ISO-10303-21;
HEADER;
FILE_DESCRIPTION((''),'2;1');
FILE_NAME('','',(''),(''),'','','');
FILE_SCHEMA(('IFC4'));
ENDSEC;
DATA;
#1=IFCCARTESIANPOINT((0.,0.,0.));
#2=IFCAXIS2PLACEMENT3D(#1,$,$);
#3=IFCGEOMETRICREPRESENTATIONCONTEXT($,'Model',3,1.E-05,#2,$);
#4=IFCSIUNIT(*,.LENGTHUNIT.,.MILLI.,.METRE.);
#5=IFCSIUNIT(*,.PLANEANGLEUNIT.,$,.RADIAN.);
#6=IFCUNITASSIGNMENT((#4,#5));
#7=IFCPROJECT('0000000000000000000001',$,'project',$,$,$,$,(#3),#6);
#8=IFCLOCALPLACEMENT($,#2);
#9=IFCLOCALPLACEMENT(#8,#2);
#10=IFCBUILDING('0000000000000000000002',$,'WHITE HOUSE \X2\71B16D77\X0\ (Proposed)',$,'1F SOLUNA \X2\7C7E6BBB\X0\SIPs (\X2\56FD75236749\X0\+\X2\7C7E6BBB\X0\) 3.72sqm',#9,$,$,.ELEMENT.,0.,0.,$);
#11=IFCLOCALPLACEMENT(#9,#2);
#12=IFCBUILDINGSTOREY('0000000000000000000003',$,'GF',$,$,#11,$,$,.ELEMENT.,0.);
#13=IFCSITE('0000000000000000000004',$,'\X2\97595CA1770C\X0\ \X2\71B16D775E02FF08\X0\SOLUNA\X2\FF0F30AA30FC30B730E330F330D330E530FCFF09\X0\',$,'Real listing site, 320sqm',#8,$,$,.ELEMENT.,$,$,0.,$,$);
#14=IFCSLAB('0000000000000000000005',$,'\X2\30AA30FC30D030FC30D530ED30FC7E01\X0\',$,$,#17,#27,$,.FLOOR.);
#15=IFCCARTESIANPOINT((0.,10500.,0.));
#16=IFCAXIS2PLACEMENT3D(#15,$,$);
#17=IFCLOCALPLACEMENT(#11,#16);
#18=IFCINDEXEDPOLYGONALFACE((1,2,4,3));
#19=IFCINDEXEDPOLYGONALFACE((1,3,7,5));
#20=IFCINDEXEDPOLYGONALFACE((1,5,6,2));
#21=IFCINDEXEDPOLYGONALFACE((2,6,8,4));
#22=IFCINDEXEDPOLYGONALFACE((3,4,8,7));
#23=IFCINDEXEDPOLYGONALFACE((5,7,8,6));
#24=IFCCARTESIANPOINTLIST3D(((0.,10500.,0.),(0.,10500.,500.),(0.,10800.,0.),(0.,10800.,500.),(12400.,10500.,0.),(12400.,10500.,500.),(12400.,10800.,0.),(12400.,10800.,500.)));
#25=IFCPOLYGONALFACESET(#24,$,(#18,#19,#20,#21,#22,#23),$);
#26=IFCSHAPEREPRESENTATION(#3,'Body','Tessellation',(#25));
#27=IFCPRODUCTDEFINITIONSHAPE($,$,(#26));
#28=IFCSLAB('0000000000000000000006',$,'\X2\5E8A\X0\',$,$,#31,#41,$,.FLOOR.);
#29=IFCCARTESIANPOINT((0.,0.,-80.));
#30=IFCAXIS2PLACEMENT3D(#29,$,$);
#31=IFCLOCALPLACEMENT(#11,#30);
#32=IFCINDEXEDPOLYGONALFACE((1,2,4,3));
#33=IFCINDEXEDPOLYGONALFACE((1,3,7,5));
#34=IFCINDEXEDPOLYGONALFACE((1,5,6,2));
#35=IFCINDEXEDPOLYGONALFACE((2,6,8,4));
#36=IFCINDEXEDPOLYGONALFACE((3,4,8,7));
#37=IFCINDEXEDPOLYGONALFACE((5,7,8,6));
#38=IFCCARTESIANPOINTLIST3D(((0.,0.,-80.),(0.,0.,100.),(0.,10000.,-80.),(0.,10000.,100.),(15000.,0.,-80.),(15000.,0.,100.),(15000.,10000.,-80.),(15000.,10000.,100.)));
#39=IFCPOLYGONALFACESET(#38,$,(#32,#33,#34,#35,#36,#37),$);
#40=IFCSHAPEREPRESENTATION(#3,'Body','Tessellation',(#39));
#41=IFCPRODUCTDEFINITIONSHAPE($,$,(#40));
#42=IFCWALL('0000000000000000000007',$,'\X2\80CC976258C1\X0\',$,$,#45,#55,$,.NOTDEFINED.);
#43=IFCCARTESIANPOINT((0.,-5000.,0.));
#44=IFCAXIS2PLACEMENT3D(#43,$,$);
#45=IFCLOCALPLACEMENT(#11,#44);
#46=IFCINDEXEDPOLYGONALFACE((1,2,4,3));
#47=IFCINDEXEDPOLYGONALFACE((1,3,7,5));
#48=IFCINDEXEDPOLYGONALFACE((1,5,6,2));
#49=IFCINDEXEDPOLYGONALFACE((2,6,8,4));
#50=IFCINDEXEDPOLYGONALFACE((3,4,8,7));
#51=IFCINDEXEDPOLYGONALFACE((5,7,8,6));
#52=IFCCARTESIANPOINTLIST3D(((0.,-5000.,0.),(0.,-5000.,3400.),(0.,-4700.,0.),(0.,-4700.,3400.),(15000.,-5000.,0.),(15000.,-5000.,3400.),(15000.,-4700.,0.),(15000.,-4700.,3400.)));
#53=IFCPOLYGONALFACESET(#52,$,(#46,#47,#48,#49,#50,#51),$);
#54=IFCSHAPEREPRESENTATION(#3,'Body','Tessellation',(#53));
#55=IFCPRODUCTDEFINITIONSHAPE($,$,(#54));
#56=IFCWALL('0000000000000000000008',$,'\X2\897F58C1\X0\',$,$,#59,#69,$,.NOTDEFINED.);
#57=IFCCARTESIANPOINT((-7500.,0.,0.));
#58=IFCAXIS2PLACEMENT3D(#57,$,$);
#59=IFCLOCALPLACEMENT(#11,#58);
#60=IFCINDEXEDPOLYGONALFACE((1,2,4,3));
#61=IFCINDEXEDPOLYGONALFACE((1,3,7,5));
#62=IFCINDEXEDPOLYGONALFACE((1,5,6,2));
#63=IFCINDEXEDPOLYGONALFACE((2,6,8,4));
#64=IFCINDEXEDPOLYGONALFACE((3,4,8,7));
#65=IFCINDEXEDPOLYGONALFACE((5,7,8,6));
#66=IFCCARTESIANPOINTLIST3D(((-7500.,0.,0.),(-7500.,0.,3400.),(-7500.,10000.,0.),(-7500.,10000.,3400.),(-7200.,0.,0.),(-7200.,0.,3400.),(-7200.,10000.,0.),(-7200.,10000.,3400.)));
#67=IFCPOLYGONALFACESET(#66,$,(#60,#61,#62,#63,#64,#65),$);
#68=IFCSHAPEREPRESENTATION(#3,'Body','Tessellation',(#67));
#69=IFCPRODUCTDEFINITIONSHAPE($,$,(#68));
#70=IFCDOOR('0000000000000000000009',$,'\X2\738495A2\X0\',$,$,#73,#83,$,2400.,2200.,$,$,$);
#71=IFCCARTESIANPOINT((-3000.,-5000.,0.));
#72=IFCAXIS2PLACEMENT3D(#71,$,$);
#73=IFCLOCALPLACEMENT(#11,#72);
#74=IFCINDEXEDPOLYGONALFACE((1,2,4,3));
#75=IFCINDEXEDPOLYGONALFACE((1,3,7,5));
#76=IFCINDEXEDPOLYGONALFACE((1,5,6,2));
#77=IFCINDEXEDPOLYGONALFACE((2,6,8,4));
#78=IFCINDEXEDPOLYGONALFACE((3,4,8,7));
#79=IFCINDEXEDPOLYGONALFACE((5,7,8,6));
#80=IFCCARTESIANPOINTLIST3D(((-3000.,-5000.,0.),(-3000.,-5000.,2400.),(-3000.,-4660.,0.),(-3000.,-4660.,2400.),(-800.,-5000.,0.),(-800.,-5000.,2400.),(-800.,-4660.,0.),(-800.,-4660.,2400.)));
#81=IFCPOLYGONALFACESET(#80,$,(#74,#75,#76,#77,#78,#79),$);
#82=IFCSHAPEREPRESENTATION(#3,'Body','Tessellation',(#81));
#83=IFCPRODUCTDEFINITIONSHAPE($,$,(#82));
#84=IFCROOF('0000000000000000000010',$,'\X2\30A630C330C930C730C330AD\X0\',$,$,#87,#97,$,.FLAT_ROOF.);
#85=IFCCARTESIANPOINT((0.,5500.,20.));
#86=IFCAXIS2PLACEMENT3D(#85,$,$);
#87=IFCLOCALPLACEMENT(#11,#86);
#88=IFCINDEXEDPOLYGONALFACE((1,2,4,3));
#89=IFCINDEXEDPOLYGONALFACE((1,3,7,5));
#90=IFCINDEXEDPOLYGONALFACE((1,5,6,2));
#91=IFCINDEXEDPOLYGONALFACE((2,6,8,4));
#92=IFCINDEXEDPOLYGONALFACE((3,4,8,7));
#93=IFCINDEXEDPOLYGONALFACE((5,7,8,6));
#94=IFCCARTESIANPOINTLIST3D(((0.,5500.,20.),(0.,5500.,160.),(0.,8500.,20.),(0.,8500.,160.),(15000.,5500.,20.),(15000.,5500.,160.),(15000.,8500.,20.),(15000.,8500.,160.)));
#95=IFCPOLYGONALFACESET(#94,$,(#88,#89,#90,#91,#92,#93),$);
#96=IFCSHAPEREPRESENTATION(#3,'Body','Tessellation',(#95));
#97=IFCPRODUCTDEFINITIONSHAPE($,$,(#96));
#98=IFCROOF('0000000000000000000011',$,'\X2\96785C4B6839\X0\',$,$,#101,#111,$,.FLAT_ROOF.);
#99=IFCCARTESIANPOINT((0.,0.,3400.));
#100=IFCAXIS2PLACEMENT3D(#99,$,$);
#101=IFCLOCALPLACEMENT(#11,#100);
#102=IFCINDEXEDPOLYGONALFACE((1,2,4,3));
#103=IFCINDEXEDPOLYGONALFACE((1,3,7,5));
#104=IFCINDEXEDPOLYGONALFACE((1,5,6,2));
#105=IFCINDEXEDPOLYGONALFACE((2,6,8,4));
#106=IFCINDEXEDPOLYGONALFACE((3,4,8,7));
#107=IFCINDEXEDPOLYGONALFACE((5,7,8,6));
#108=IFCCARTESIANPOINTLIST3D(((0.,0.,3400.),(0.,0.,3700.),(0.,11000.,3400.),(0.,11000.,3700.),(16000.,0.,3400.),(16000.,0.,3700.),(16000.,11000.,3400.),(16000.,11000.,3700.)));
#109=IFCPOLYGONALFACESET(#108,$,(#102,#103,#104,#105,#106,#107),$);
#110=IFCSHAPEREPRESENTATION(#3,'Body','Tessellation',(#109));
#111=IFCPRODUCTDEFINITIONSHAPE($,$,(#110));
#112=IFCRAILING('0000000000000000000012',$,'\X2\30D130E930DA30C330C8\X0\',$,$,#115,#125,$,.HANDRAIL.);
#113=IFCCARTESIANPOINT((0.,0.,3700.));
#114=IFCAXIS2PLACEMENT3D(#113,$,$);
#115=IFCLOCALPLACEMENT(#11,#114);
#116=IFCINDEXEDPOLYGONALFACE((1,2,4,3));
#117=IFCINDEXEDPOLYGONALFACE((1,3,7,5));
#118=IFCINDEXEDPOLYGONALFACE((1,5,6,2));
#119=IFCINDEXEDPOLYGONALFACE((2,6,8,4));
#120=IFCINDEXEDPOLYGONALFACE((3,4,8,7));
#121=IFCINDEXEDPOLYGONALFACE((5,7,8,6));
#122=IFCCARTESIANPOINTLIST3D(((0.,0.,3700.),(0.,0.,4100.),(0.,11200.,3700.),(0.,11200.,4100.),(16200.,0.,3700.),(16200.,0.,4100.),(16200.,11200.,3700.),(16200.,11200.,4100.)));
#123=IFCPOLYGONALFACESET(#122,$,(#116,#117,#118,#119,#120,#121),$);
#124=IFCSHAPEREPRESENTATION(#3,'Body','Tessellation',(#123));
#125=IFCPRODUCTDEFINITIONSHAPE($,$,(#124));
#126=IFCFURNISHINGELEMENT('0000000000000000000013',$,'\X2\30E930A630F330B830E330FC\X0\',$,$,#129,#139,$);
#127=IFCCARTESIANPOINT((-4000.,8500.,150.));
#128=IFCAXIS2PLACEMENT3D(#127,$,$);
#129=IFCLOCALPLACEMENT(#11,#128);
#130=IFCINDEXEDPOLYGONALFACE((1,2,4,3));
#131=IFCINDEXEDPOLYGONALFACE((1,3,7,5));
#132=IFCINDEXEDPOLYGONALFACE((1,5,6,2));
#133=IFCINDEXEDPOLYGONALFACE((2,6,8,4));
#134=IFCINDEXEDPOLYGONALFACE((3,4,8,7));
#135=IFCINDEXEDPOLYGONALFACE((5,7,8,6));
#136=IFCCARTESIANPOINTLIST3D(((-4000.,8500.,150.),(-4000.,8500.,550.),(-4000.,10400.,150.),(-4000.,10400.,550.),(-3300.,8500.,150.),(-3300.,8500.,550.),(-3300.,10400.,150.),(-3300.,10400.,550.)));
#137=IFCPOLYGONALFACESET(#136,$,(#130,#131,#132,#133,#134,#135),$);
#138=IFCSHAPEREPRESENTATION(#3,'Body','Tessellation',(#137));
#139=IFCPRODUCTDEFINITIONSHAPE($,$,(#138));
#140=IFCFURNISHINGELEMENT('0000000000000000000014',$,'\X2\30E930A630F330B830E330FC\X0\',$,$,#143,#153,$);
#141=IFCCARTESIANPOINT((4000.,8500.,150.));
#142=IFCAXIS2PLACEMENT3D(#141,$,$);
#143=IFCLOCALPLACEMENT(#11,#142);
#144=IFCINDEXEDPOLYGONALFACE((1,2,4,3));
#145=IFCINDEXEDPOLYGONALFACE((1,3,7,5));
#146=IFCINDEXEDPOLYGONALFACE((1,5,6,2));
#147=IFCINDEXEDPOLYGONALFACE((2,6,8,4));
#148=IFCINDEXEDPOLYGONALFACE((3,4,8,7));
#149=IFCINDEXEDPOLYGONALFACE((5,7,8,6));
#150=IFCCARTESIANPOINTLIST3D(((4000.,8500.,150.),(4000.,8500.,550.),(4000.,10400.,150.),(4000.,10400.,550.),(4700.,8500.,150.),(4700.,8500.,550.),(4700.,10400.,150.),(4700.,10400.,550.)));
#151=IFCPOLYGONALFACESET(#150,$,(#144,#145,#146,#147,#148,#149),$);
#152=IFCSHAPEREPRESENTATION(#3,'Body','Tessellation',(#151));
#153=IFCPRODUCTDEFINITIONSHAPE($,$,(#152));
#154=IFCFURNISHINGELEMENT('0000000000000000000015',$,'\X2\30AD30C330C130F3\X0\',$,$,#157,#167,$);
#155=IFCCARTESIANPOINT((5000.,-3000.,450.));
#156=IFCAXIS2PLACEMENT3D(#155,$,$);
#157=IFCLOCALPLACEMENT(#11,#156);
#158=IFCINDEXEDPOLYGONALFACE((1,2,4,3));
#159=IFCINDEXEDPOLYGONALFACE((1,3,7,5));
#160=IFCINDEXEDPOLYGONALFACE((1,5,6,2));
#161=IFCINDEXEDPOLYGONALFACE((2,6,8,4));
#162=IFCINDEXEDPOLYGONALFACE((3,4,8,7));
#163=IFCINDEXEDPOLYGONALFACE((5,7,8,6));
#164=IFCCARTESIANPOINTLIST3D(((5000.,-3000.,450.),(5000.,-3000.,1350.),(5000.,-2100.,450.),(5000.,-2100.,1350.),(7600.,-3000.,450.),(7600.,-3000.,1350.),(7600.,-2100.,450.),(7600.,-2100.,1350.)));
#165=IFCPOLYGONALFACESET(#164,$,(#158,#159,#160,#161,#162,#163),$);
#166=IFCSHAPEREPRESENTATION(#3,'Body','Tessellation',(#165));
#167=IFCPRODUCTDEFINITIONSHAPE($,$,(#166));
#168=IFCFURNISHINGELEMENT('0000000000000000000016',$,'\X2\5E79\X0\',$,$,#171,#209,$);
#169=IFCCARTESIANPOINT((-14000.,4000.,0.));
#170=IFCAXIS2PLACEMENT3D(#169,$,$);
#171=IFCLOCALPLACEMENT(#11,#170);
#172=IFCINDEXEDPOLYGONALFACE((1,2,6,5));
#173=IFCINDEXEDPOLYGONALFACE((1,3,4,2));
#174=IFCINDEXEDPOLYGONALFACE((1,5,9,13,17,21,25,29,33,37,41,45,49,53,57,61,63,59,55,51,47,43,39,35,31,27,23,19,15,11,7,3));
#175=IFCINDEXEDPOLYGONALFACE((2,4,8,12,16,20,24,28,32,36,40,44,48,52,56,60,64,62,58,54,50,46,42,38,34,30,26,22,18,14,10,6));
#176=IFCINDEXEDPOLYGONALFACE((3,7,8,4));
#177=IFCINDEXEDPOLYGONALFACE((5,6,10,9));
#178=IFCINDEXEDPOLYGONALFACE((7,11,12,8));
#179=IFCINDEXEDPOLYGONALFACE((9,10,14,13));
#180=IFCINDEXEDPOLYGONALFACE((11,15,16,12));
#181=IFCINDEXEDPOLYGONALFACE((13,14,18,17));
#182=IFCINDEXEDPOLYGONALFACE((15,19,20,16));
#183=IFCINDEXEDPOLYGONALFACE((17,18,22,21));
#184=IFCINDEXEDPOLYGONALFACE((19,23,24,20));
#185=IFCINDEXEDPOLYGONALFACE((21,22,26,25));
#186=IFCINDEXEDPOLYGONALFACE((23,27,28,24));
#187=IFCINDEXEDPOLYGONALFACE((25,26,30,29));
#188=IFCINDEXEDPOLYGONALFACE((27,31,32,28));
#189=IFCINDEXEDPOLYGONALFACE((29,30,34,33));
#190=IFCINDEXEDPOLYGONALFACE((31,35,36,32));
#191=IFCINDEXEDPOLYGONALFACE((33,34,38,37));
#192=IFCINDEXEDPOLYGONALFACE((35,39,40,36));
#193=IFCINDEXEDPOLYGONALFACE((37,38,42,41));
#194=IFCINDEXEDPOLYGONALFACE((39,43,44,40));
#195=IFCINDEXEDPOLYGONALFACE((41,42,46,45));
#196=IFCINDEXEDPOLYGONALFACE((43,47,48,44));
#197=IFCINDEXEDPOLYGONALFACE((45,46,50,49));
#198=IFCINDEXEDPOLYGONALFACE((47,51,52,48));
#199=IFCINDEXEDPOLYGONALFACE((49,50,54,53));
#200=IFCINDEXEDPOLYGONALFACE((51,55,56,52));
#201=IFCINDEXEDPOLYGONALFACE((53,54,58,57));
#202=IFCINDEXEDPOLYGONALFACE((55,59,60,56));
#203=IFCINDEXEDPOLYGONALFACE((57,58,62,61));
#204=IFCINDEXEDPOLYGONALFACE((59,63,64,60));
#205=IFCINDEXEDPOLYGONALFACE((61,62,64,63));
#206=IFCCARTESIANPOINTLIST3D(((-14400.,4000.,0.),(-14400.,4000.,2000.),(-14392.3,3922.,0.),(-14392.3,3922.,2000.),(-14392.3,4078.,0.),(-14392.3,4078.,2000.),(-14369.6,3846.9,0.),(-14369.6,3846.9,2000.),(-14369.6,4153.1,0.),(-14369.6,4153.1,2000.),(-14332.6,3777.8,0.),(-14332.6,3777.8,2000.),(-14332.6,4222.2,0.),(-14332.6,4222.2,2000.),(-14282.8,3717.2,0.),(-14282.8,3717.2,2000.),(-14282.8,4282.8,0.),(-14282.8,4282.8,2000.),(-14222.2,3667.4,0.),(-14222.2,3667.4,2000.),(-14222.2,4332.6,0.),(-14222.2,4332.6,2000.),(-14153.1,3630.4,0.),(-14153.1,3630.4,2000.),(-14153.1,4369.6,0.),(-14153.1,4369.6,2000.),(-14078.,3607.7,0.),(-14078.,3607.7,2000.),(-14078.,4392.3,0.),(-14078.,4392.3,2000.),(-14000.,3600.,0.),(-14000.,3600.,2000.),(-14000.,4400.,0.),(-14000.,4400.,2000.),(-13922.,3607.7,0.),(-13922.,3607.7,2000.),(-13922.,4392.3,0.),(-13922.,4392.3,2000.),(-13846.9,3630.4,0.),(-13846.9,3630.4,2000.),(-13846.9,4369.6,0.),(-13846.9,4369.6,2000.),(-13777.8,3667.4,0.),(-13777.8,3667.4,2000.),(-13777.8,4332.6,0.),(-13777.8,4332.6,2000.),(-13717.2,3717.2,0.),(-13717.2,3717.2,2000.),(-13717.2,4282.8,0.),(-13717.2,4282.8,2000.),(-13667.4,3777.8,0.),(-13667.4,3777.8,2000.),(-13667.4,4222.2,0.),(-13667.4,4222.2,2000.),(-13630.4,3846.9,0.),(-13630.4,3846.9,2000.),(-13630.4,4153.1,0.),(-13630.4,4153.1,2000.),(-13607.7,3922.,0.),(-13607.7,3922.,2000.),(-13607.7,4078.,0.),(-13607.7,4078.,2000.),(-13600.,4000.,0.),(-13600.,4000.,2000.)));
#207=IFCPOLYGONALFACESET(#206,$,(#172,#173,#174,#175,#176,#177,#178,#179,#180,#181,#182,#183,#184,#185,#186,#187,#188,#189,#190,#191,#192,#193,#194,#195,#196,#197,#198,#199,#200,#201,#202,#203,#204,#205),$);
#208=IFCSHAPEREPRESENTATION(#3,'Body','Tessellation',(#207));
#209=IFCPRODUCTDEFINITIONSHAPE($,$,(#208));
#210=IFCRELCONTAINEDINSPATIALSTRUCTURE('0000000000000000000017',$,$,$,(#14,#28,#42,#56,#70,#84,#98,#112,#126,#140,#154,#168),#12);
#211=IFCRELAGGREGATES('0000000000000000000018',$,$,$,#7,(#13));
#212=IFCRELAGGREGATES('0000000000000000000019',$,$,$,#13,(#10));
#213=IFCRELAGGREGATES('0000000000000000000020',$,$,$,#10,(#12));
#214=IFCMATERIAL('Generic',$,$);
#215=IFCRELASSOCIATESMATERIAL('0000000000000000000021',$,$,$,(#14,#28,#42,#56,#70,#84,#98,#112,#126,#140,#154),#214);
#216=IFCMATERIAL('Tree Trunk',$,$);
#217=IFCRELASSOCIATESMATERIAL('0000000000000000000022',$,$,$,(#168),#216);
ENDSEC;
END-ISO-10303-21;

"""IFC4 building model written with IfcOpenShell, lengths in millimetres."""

from ifc_helpers import new_model, si_unit, frame, frame_2d, origin, origin_2d, place, context, project, spatial, rectangle, circle, extrude, material, element, save


model = new_model("IFC4")

# Units and contexts
model_context = context("Model", 3, precision=1e-05, world=origin())
ifc_project = project(units=[si_unit("LENGTHUNIT", "METRE", prefix="MILLI"), si_unit("PLANEANGLEUNIT", "RADIAN")], contexts=[model_context])

# Site, building, storey
site_placement = place(None, origin())
site = spatial("IfcSite", under=ifc_project, at=site_placement, Name="静岡県 熱海市（SOLUNA／オーシャンビュー）", ObjectType="Real listing site, 320sqm", CompositionType="ELEMENT", RefElevation=0.0)
building_placement = place(site_placement, origin())
building = spatial("IfcBuilding", under=site, at=building_placement, Name="WHITE HOUSE 熱海 (Proposed)", ObjectType="1F SOLUNA 籾殻SIPs (国産杉+籾殻) 3.72sqm", CompositionType="ELEMENT", ElevationOfRefHeight=0.0, ElevationOfTerrain=0.0)
storey_placement = place(building_placement, origin())
storey = spatial("IfcBuildingStorey", under=building, at=storey_placement, Name="GF", CompositionType="ELEMENT", Elevation=0.0)

# Slabs
ifc_material_1 = material(Name="Generic")
slab_1_placement = place(storey_placement, frame((0.0, 10500.0, 0.0)))
element("IfcSlab", 1, at=slab_1_placement, inside=storey, material=ifc_material_1, Name="オーバーフロー縁", PredefinedType="FLOOR", context=model_context, shape_type="SweptSolid", body=[
    extrude(rectangle(XDim=12400.0, YDim=300.0, at=frame_2d((6200.0, 150.0))), frame((0.0, 10500.0, 0.0)), (0.0, 0.0, 1.0), 500.0),
])
slab_2_placement = place(storey_placement, frame((0.0, 0.0, -80.0)))
element("IfcSlab", 2, at=slab_2_placement, inside=storey, material=ifc_material_1, Name="床", PredefinedType="FLOOR", context=model_context, shape_type="SweptSolid", body=[
    extrude(rectangle(XDim=15000.0, YDim=10000.0, at=frame_2d((7500.0, 5000.0))), frame((0.0, 0.0, -80.0)), (0.0, 0.0, 1.0), 180.0),
])

# Walls
wall_1_placement = place(storey_placement, frame((0.0, -5000.0, 0.0)))
element("IfcWall", 3, at=wall_1_placement, inside=storey, material=ifc_material_1, Name="背面壁", PredefinedType="NOTDEFINED", context=model_context, shape_type="SweptSolid", body=[
    extrude(rectangle(XDim=15000.0, YDim=300.0, at=frame_2d((7500.0, 150.0))), frame((0.0, -5000.0, 0.0)), (0.0, 0.0, 1.0), 3400.0),
])
wall_2_placement = place(storey_placement, frame((-7500.0, 0.0, 0.0)))
element("IfcWall", 4, at=wall_2_placement, inside=storey, material=ifc_material_1, Name="西壁", PredefinedType="NOTDEFINED", context=model_context, shape_type="SweptSolid", body=[
    extrude(rectangle(XDim=300.0, YDim=10000.0, at=frame_2d((150.0, 5000.0))), frame((-7500.0, 0.0, 0.0)), (0.0, 0.0, 1.0), 3400.0),
])

# Door
door_placement = place(storey_placement, frame((-3000.0, -5000.0, 0.0)))
element("IfcDoor", 5, at=door_placement, inside=storey, material=ifc_material_1, Name="玄関", OverallHeight=2400.0, OverallWidth=2200.0, context=model_context, shape_type="SweptSolid", body=[
    extrude(rectangle(XDim=2200.0, YDim=340.0, at=frame_2d((1100.0, 170.0))), frame((-3000.0, -5000.0, 0.0)), (0.0, 0.0, 1.0), 2400.0),
])

# Roofs
roof_1_placement = place(storey_placement, frame((0.0, 5500.0, 20.0)))
element("IfcRoof", 6, at=roof_1_placement, inside=storey, material=ifc_material_1, Name="ウッドデッキ", PredefinedType="FLAT_ROOF", context=model_context, shape_type="SweptSolid", body=[
    extrude(rectangle(XDim=15000.0, YDim=3000.0, at=frame_2d((7500.0, 1500.0))), frame((0.0, 5500.0, 20.0)), (0.0, 0.0, 1.0), 140.0),
])
roof_2_placement = place(storey_placement, frame((0.0, 0.0, 3400.0)))
element("IfcRoof", 7, at=roof_2_placement, inside=storey, material=ifc_material_1, Name="陸屋根", PredefinedType="FLAT_ROOF", context=model_context, shape_type="SweptSolid", body=[
    extrude(rectangle(XDim=16000.0, YDim=11000.0, at=frame_2d((8000.0, 5500.0))), frame((0.0, 0.0, 3400.0)), (0.0, 0.0, 1.0), 300.0),
])

# Railing
railing_placement = place(storey_placement, frame((0.0, 0.0, 3700.0)))
element("IfcRailing", 8, at=railing_placement, inside=storey, material=ifc_material_1, Name="パラペット", PredefinedType="HANDRAIL", context=model_context, shape_type="SweptSolid", body=[
    extrude(rectangle(XDim=16200.0, YDim=11200.0, at=frame_2d((8100.0, 5600.0))), frame((0.0, 0.0, 3700.0)), (0.0, 0.0, 1.0), 400.0),
])

# Furnishing elements
furnishing_1_placement = place(storey_placement, frame((-4000.0, 8500.0, 150.0)))
element("IfcFurnishingElement", 9, at=furnishing_1_placement, inside=storey, material=ifc_material_1, Name="ラウンジャー", context=model_context, shape_type="SweptSolid", body=[
    extrude(rectangle(XDim=700.0, YDim=1900.0, at=frame_2d((350.0, 950.0))), frame((-4000.0, 8500.0, 150.0)), (0.0, 0.0, 1.0), 400.0),
])
furnishing_2_placement = place(storey_placement, frame((4000.0, 8500.0, 150.0)))
element("IfcFurnishingElement", 10, at=furnishing_2_placement, inside=storey, material=ifc_material_1, Name="ラウンジャー", context=model_context, shape_type="SweptSolid", body=[
    extrude(rectangle(XDim=700.0, YDim=1900.0, at=frame_2d((350.0, 950.0))), frame((4000.0, 8500.0, 150.0)), (0.0, 0.0, 1.0), 400.0),
])
furnishing_3_placement = place(storey_placement, frame((5000.0, -3000.0, 450.0)))
element("IfcFurnishingElement", 11, at=furnishing_3_placement, inside=storey, material=ifc_material_1, Name="キッチン", context=model_context, shape_type="SweptSolid", body=[
    extrude(rectangle(XDim=2600.0, YDim=900.0, at=frame_2d((1300.0, 450.0))), frame((5000.0, -3000.0, 450.0)), (0.0, 0.0, 1.0), 900.0),
])
ifc_material_2 = material(Name="Tree Trunk")
furnishing_4_placement = place(storey_placement, frame((-14000.0, 4000.0, 0.0)))
element("IfcFurnishingElement", 12, at=furnishing_4_placement, inside=storey, material=ifc_material_2, Name="幹", context=model_context, shape_type="SweptSolid", body=[
    extrude(circle(Radius=400.0, at=origin_2d()), frame((-14000.0, 4000.0, 0.0)), (0.0, 0.0, 1.0), 2000.0),
])

save(model, "model.ifc")
